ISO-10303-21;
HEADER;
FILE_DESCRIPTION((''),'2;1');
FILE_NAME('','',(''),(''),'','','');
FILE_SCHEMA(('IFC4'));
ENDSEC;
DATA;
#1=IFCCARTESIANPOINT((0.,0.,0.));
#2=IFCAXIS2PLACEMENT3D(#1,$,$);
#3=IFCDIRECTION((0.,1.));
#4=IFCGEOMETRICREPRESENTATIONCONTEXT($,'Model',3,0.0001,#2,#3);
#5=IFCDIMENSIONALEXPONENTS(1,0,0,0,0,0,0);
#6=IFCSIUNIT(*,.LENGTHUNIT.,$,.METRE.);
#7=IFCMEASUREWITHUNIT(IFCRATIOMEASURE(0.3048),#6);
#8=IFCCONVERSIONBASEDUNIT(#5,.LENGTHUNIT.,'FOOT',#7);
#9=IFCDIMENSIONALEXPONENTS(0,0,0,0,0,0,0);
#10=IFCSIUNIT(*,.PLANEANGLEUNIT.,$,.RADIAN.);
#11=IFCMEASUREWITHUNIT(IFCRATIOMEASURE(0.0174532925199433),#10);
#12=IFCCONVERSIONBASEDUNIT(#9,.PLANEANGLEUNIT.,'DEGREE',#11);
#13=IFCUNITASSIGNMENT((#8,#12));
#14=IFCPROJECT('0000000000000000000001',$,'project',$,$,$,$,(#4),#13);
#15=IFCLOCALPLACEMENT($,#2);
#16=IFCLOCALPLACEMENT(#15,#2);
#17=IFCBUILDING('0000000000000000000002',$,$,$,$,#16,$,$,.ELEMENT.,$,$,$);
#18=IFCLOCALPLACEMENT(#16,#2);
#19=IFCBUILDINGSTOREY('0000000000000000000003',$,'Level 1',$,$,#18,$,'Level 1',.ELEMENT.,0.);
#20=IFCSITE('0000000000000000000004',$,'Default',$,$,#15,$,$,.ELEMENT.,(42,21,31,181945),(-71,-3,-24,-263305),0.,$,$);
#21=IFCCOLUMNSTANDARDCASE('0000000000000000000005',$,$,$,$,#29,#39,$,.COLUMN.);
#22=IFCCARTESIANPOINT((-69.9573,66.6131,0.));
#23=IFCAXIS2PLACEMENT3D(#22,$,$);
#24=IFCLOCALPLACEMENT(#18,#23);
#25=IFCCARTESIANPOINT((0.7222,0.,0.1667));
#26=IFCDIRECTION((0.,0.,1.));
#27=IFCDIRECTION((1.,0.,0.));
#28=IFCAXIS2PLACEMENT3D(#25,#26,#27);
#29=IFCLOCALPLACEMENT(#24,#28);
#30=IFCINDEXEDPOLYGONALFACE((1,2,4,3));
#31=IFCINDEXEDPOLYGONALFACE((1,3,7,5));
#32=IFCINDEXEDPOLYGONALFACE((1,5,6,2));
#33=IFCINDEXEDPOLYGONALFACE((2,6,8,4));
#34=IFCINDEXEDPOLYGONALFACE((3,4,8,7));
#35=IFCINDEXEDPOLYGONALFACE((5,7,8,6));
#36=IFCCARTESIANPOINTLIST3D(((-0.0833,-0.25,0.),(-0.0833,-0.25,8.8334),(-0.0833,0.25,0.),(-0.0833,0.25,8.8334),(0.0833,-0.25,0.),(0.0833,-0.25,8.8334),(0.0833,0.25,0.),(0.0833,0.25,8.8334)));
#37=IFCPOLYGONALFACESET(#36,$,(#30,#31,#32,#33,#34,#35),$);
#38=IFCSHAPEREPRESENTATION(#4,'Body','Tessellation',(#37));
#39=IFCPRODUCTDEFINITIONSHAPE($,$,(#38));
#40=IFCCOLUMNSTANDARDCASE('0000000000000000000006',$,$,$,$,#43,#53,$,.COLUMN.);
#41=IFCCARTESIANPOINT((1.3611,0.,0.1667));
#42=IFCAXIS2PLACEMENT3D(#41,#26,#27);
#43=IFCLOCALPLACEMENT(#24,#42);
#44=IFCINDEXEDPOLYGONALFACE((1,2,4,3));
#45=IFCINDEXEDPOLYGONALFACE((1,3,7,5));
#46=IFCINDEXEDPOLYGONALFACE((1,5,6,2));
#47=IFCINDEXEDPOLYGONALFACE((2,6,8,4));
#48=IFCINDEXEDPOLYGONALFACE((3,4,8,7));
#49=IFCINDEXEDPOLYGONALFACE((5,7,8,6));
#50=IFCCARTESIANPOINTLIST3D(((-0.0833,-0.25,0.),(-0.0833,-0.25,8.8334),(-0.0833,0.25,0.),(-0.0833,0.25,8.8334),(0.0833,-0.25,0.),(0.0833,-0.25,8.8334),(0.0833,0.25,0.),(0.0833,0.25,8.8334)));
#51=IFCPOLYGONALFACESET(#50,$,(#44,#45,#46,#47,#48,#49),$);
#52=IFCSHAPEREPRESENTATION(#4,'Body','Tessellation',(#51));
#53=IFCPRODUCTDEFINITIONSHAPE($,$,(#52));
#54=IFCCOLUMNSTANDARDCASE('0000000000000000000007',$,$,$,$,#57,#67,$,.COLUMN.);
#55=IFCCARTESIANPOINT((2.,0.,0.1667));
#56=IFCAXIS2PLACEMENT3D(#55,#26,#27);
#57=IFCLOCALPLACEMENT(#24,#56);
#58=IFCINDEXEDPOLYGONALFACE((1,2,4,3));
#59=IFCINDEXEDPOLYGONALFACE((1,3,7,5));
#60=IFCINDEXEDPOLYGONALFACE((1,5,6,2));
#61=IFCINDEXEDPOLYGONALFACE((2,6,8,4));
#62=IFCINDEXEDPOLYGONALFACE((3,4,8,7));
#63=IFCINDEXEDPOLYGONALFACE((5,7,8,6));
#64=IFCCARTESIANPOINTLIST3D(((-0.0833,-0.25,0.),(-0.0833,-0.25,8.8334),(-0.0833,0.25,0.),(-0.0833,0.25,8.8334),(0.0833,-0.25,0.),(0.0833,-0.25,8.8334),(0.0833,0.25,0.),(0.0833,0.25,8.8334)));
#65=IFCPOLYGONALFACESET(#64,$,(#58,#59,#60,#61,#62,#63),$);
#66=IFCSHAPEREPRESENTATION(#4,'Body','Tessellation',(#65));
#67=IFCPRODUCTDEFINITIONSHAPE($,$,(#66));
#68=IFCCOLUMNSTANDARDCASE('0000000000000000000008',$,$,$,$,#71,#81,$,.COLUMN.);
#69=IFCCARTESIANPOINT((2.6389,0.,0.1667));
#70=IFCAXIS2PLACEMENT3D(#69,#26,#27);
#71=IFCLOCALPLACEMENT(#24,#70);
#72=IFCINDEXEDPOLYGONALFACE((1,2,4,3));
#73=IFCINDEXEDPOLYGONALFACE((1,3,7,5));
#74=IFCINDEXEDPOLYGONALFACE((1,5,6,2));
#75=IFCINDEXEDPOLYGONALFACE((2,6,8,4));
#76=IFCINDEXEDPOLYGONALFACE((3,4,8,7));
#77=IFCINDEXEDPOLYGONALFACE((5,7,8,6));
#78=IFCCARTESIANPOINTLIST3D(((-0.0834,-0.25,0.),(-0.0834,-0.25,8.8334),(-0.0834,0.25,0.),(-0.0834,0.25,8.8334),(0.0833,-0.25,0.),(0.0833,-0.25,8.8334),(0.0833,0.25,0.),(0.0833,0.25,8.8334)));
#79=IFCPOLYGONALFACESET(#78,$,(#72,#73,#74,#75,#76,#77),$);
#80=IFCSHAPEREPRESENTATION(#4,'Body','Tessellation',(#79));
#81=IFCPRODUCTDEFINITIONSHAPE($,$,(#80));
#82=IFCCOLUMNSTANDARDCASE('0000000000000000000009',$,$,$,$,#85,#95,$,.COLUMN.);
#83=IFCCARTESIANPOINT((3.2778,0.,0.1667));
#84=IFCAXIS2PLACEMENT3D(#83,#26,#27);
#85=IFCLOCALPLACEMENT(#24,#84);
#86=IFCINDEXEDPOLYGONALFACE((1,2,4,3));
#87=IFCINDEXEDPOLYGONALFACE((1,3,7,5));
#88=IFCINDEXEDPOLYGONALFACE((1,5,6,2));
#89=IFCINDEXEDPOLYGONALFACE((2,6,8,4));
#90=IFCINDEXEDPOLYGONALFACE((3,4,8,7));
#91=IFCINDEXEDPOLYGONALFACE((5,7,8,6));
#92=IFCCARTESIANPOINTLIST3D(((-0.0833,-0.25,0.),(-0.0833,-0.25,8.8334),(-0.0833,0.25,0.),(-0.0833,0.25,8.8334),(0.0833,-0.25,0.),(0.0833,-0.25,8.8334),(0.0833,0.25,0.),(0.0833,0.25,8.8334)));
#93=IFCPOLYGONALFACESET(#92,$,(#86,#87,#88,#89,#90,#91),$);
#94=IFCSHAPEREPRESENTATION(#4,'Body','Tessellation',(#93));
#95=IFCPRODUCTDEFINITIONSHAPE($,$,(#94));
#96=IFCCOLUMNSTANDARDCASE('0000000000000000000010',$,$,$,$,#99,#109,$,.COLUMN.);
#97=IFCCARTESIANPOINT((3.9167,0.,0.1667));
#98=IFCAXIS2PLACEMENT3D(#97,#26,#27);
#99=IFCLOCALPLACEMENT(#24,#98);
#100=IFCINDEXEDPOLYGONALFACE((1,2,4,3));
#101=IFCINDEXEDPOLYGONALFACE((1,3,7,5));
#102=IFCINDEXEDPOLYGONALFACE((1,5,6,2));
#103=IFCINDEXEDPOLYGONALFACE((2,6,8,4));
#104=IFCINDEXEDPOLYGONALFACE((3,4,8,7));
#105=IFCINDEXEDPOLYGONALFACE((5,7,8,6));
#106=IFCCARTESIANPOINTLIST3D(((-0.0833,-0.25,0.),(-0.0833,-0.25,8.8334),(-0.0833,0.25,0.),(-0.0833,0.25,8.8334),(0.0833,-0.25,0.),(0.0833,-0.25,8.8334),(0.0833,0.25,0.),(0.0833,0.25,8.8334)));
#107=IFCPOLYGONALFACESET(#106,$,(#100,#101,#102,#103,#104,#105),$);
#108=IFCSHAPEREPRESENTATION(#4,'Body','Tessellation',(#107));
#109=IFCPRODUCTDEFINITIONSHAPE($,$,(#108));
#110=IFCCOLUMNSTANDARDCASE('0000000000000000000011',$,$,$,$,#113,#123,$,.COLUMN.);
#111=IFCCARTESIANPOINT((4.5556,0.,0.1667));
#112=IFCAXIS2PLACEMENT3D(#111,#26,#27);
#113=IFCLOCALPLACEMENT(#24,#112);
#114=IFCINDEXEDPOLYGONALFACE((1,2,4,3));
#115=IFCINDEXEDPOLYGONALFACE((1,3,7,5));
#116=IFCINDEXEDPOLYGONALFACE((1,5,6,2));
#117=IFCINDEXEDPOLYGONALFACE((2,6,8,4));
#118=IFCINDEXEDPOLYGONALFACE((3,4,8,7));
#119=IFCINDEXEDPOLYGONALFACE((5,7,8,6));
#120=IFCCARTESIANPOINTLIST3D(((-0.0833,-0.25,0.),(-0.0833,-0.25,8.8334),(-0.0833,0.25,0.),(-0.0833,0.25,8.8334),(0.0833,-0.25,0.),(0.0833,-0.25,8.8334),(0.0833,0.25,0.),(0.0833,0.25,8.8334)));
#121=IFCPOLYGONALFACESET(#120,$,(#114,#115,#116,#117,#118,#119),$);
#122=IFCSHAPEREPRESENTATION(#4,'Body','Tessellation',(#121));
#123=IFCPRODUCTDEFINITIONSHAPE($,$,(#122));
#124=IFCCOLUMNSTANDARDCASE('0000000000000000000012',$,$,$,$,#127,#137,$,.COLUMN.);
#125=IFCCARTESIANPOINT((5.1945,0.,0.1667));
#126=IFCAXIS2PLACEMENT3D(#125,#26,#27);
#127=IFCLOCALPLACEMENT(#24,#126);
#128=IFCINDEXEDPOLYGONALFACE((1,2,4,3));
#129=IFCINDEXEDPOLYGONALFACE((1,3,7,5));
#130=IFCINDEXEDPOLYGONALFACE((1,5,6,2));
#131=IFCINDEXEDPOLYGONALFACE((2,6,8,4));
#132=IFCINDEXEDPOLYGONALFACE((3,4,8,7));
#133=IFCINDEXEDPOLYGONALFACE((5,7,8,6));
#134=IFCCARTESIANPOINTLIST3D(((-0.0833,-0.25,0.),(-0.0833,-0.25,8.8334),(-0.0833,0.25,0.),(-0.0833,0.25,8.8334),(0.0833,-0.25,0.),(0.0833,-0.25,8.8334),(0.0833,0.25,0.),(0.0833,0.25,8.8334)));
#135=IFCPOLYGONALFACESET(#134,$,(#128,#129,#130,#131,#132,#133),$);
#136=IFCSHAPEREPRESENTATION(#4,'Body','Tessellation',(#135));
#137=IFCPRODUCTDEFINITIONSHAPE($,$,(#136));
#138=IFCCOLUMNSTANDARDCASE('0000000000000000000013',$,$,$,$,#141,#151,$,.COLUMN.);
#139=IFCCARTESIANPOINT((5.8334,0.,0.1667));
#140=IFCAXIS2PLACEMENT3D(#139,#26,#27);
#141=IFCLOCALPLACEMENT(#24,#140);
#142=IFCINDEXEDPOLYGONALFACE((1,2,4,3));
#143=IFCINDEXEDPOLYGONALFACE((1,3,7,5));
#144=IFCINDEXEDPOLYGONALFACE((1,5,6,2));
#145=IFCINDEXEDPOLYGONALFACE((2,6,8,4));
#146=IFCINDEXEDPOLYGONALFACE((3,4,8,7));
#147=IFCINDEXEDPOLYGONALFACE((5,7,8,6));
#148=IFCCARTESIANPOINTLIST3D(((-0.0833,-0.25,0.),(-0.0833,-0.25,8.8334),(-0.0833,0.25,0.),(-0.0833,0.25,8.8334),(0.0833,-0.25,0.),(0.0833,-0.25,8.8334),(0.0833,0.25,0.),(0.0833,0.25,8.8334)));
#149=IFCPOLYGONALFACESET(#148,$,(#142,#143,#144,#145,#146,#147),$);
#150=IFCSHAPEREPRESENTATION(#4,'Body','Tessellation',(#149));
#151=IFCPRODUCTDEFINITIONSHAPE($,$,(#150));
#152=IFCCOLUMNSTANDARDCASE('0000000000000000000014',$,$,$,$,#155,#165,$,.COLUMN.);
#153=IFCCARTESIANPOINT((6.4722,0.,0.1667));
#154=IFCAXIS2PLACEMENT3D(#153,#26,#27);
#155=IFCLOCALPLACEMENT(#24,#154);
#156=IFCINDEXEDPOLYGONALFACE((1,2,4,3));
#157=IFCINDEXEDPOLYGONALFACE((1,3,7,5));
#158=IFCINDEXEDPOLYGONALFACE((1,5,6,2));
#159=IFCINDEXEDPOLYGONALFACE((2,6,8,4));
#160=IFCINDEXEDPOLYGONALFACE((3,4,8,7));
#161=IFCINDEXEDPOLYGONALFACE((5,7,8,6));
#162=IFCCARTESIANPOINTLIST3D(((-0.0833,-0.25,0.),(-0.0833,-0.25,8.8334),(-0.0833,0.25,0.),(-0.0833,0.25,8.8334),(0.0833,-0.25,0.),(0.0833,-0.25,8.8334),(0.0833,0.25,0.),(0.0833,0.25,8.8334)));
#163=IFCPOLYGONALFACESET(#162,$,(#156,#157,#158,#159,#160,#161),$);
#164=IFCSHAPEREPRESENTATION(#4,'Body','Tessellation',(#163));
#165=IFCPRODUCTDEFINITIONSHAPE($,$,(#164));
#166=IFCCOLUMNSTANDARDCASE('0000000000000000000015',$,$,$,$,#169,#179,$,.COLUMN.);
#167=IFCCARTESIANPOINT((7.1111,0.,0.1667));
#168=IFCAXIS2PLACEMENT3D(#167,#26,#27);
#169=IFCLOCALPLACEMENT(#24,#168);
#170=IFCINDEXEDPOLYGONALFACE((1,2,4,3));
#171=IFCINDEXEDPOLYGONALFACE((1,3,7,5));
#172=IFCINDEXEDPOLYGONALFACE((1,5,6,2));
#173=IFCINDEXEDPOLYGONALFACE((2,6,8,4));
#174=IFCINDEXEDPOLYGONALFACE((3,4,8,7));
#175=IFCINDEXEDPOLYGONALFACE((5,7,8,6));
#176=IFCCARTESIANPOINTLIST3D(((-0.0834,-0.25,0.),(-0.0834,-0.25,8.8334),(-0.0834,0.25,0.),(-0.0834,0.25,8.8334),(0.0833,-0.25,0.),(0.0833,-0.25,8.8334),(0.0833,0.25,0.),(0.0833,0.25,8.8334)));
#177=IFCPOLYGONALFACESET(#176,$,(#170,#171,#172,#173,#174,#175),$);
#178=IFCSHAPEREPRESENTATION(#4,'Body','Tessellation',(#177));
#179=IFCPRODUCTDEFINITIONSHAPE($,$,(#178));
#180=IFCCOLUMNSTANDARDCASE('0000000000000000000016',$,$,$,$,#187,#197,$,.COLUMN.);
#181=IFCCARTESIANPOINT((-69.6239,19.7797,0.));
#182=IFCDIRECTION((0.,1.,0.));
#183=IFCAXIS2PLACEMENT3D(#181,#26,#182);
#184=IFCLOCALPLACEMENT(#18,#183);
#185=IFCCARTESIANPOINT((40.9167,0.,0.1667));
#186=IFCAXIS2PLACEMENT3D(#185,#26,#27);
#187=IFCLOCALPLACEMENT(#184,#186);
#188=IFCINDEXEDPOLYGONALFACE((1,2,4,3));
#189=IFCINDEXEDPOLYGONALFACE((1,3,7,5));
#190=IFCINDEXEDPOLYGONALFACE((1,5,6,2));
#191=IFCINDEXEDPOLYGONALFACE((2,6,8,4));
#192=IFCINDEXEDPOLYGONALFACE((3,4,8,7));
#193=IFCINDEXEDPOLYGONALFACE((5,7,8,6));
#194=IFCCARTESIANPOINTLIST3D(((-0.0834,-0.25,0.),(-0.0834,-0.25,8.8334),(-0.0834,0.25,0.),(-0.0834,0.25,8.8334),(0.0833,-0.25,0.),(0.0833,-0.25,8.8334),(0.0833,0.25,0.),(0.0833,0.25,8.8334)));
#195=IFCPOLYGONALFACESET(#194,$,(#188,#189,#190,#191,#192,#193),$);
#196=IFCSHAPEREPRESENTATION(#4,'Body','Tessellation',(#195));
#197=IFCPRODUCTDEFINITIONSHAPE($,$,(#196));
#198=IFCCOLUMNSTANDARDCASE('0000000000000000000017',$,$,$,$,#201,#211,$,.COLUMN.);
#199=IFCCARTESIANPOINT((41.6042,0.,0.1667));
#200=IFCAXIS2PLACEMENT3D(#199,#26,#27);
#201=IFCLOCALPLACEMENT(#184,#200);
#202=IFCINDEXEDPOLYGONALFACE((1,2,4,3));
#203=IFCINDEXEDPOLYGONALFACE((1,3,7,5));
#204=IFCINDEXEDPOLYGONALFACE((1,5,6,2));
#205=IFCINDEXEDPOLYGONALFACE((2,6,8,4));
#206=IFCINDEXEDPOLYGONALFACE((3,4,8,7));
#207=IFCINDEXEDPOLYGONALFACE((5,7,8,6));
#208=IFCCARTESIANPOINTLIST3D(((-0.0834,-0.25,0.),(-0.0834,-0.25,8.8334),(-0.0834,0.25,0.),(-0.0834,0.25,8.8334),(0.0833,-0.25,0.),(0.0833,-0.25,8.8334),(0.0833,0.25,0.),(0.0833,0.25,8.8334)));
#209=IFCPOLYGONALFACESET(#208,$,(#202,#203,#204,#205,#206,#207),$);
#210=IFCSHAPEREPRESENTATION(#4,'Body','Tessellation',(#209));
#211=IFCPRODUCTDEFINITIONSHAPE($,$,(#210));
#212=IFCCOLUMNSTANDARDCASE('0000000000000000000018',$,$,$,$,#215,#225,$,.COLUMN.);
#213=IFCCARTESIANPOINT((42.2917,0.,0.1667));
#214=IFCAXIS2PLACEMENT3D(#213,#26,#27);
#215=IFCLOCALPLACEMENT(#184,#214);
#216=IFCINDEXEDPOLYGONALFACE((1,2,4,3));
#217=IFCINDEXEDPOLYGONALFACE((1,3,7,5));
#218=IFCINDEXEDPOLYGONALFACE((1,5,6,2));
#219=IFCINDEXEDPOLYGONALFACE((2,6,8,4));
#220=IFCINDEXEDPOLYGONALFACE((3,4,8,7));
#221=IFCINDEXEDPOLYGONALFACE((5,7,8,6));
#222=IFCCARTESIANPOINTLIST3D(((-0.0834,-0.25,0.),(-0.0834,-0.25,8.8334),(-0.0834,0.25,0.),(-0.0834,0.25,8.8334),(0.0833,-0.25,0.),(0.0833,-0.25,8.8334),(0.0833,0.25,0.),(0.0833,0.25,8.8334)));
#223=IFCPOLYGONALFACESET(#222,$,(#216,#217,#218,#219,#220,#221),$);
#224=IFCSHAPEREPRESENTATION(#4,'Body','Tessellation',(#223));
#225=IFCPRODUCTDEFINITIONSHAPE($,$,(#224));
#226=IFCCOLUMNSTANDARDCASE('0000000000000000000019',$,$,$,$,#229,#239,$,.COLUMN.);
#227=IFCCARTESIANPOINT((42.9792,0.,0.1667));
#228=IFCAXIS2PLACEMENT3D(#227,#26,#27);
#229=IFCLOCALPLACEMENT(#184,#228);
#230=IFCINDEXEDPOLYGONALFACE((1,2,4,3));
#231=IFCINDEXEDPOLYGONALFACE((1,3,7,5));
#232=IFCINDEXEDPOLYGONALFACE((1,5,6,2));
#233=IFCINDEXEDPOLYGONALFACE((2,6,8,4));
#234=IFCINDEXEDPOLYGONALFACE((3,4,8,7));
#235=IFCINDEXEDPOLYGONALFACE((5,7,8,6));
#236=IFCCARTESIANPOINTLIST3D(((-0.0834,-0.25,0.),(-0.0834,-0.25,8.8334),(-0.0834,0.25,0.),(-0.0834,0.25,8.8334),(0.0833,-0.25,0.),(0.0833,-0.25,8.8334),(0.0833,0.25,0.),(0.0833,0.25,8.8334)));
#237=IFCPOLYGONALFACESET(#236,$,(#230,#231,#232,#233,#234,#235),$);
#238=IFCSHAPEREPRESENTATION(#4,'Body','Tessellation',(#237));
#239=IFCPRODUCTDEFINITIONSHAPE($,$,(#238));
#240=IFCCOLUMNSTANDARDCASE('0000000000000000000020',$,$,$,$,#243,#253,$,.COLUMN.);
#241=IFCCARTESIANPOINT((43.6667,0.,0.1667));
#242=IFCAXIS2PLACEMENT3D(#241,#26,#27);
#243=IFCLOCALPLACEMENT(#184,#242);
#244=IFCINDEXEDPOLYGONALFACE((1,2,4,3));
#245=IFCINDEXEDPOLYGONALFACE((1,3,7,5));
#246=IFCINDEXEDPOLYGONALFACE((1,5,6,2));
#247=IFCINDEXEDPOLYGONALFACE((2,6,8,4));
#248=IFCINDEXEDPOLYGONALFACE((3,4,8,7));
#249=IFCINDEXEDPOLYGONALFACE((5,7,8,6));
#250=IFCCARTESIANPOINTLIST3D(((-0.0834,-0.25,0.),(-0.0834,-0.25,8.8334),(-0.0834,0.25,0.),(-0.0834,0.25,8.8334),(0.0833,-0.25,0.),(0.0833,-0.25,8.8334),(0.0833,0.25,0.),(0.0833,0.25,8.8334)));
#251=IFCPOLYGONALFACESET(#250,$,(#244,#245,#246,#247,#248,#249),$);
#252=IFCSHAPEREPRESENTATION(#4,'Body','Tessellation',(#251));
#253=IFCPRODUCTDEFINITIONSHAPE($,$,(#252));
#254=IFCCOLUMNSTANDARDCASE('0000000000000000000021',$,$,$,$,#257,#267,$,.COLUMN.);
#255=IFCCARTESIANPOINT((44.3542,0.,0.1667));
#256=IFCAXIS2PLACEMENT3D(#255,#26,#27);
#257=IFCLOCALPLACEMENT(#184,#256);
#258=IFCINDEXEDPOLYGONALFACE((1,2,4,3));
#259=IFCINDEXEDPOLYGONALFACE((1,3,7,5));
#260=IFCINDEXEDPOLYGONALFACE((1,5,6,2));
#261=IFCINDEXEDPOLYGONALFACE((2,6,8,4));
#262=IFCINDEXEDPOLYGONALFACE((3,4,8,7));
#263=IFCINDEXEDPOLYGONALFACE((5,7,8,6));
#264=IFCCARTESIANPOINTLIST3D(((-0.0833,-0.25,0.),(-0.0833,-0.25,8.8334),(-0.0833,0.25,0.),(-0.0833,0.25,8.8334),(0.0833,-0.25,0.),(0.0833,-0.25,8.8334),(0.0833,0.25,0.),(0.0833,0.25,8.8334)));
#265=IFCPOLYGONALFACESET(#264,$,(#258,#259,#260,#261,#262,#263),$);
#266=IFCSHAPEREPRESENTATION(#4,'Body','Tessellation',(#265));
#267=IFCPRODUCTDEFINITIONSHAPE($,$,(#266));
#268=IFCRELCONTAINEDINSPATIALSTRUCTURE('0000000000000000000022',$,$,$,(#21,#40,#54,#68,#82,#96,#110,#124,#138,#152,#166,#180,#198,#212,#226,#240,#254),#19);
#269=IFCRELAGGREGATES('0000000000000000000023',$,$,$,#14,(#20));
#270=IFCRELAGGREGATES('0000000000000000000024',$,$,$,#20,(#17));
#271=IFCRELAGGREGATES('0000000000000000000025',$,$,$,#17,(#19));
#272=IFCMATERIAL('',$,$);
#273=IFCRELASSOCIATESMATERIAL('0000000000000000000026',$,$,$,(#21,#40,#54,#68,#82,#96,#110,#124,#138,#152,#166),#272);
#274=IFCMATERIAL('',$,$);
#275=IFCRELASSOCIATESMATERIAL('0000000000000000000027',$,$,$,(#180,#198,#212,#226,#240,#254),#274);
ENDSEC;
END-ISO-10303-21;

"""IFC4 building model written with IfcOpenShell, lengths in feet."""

from ifc_helpers import new_model, entity, si_unit, converted_unit, direction, frame, origin, place, context, project, spatial, rectangle, extrude, material, element, save


model = new_model("IFC4")

# Units and contexts
model_context = context("Model", 3, precision=0.0001, world=origin(), true_north=direction((0.0, 1.0)))
ifc_project = project(units=[converted_unit("LENGTHUNIT", "FOOT", entity("IfcRatioMeasure", 0.3048), si_unit("LENGTHUNIT", "METRE"), dimensions=[1, 0, 0, 0, 0, 0, 0]), converted_unit("PLANEANGLEUNIT", "DEGREE", entity("IfcRatioMeasure", 0.0174532925199433), si_unit("PLANEANGLEUNIT", "RADIAN"), dimensions=[0, 0, 0, 0, 0, 0, 0])], contexts=[model_context])

# Site, building, storey
site_placement = place(None, origin())
site = spatial("IfcSite", under=ifc_project, at=site_placement, Name="Default", CompositionType="ELEMENT", RefLatitude=(42, 21, 31, 181945), RefLongitude=(-71, -3, -24, -263305), RefElevation=0.0)
building_placement = place(site_placement, origin())
building = spatial("IfcBuilding", under=site, at=building_placement, CompositionType="ELEMENT")
storey_placement = place(building_placement, origin())
storey = spatial("IfcBuildingStorey", under=building, at=storey_placement, Name="Level 1", LongName="Level 1", CompositionType="ELEMENT", Elevation=0.0)

# Columns
ifc_material_1 = material(Name="")
placement_1 = place(storey_placement, frame((-69.9573, 66.6131, 0.0)))
for number, where, z_axis, x_axis in (
    (1, (0.7222, 0.0, 0.1667), (0.0, 0.0, 1.0), (1.0, 0.0, 0.0)),
    (2, (1.3611, 0.0, 0.1667), (0.0, 0.0, 1.0), (1.0, 0.0, 0.0)),
    (3, (2.0, 0.0, 0.1667), (0.0, 0.0, 1.0), (1.0, 0.0, 0.0)),
    (4, (2.6389, 0.0, 0.1667), (0.0, 0.0, 1.0), (1.0, 0.0, 0.0)),
    (5, (3.2778, 0.0, 0.1667), (0.0, 0.0, 1.0), (1.0, 0.0, 0.0)),
    (6, (3.9167, 0.0, 0.1667), (0.0, 0.0, 1.0), (1.0, 0.0, 0.0)),
    (7, (4.5556, 0.0, 0.1667), (0.0, 0.0, 1.0), (1.0, 0.0, 0.0)),
    (8, (5.1945, 0.0, 0.1667), (0.0, 0.0, 1.0), (1.0, 0.0, 0.0)),
    (9, (5.8334, 0.0, 0.1667), (0.0, 0.0, 1.0), (1.0, 0.0, 0.0)),
    (10, (6.4722, 0.0, 0.1667), (0.0, 0.0, 1.0), (1.0, 0.0, 0.0)),
    (11, (7.1111, 0.0, 0.1667), (0.0, 0.0, 1.0), (1.0, 0.0, 0.0)),
):
    element("IfcColumnStandardCase", number, at=place(placement_1, frame(where, z_axis=z_axis, x_axis=x_axis)), inside=storey, material=ifc_material_1, PredefinedType="COLUMN", context=model_context, shape_type="SweptSolid", body=[
        extrude(rectangle(XDim=0.1667, YDim=0.5), origin(), (0.0, 0.0, 1.0), 8.8334),
    ])
ifc_material_2 = material(Name="")
placement_2 = place(storey_placement, frame((-69.6239, 19.7797, 0.0), z_axis=(0.0, 0.0, 1.0), x_axis=(0.0, 1.0, 0.0)))
for number, where, z_axis, x_axis in (
    (12, (40.9167, 0.0, 0.1667), (0.0, 0.0, 1.0), (1.0, 0.0, 0.0)),
    (13, (41.6042, 0.0, 0.1667), (0.0, 0.0, 1.0), (1.0, 0.0, 0.0)),
    (14, (42.2917, 0.0, 0.1667), (0.0, 0.0, 1.0), (1.0, 0.0, 0.0)),
    (15, (42.9792, 0.0, 0.1667), (0.0, 0.0, 1.0), (1.0, 0.0, 0.0)),
    (16, (43.6667, 0.0, 0.1667), (0.0, 0.0, 1.0), (1.0, 0.0, 0.0)),
    (17, (44.3542, 0.0, 0.1667), (0.0, 0.0, 1.0), (1.0, 0.0, 0.0)),
):
    element("IfcColumnStandardCase", number, at=place(placement_2, frame(where, z_axis=z_axis, x_axis=x_axis)), inside=storey, material=ifc_material_2, PredefinedType="COLUMN", context=model_context, shape_type="SweptSolid", body=[
        extrude(rectangle(XDim=0.1667, YDim=0.5), origin(), (0.0, 0.0, 1.0), 8.8334),
    ])

save(model, "model.ifc")
